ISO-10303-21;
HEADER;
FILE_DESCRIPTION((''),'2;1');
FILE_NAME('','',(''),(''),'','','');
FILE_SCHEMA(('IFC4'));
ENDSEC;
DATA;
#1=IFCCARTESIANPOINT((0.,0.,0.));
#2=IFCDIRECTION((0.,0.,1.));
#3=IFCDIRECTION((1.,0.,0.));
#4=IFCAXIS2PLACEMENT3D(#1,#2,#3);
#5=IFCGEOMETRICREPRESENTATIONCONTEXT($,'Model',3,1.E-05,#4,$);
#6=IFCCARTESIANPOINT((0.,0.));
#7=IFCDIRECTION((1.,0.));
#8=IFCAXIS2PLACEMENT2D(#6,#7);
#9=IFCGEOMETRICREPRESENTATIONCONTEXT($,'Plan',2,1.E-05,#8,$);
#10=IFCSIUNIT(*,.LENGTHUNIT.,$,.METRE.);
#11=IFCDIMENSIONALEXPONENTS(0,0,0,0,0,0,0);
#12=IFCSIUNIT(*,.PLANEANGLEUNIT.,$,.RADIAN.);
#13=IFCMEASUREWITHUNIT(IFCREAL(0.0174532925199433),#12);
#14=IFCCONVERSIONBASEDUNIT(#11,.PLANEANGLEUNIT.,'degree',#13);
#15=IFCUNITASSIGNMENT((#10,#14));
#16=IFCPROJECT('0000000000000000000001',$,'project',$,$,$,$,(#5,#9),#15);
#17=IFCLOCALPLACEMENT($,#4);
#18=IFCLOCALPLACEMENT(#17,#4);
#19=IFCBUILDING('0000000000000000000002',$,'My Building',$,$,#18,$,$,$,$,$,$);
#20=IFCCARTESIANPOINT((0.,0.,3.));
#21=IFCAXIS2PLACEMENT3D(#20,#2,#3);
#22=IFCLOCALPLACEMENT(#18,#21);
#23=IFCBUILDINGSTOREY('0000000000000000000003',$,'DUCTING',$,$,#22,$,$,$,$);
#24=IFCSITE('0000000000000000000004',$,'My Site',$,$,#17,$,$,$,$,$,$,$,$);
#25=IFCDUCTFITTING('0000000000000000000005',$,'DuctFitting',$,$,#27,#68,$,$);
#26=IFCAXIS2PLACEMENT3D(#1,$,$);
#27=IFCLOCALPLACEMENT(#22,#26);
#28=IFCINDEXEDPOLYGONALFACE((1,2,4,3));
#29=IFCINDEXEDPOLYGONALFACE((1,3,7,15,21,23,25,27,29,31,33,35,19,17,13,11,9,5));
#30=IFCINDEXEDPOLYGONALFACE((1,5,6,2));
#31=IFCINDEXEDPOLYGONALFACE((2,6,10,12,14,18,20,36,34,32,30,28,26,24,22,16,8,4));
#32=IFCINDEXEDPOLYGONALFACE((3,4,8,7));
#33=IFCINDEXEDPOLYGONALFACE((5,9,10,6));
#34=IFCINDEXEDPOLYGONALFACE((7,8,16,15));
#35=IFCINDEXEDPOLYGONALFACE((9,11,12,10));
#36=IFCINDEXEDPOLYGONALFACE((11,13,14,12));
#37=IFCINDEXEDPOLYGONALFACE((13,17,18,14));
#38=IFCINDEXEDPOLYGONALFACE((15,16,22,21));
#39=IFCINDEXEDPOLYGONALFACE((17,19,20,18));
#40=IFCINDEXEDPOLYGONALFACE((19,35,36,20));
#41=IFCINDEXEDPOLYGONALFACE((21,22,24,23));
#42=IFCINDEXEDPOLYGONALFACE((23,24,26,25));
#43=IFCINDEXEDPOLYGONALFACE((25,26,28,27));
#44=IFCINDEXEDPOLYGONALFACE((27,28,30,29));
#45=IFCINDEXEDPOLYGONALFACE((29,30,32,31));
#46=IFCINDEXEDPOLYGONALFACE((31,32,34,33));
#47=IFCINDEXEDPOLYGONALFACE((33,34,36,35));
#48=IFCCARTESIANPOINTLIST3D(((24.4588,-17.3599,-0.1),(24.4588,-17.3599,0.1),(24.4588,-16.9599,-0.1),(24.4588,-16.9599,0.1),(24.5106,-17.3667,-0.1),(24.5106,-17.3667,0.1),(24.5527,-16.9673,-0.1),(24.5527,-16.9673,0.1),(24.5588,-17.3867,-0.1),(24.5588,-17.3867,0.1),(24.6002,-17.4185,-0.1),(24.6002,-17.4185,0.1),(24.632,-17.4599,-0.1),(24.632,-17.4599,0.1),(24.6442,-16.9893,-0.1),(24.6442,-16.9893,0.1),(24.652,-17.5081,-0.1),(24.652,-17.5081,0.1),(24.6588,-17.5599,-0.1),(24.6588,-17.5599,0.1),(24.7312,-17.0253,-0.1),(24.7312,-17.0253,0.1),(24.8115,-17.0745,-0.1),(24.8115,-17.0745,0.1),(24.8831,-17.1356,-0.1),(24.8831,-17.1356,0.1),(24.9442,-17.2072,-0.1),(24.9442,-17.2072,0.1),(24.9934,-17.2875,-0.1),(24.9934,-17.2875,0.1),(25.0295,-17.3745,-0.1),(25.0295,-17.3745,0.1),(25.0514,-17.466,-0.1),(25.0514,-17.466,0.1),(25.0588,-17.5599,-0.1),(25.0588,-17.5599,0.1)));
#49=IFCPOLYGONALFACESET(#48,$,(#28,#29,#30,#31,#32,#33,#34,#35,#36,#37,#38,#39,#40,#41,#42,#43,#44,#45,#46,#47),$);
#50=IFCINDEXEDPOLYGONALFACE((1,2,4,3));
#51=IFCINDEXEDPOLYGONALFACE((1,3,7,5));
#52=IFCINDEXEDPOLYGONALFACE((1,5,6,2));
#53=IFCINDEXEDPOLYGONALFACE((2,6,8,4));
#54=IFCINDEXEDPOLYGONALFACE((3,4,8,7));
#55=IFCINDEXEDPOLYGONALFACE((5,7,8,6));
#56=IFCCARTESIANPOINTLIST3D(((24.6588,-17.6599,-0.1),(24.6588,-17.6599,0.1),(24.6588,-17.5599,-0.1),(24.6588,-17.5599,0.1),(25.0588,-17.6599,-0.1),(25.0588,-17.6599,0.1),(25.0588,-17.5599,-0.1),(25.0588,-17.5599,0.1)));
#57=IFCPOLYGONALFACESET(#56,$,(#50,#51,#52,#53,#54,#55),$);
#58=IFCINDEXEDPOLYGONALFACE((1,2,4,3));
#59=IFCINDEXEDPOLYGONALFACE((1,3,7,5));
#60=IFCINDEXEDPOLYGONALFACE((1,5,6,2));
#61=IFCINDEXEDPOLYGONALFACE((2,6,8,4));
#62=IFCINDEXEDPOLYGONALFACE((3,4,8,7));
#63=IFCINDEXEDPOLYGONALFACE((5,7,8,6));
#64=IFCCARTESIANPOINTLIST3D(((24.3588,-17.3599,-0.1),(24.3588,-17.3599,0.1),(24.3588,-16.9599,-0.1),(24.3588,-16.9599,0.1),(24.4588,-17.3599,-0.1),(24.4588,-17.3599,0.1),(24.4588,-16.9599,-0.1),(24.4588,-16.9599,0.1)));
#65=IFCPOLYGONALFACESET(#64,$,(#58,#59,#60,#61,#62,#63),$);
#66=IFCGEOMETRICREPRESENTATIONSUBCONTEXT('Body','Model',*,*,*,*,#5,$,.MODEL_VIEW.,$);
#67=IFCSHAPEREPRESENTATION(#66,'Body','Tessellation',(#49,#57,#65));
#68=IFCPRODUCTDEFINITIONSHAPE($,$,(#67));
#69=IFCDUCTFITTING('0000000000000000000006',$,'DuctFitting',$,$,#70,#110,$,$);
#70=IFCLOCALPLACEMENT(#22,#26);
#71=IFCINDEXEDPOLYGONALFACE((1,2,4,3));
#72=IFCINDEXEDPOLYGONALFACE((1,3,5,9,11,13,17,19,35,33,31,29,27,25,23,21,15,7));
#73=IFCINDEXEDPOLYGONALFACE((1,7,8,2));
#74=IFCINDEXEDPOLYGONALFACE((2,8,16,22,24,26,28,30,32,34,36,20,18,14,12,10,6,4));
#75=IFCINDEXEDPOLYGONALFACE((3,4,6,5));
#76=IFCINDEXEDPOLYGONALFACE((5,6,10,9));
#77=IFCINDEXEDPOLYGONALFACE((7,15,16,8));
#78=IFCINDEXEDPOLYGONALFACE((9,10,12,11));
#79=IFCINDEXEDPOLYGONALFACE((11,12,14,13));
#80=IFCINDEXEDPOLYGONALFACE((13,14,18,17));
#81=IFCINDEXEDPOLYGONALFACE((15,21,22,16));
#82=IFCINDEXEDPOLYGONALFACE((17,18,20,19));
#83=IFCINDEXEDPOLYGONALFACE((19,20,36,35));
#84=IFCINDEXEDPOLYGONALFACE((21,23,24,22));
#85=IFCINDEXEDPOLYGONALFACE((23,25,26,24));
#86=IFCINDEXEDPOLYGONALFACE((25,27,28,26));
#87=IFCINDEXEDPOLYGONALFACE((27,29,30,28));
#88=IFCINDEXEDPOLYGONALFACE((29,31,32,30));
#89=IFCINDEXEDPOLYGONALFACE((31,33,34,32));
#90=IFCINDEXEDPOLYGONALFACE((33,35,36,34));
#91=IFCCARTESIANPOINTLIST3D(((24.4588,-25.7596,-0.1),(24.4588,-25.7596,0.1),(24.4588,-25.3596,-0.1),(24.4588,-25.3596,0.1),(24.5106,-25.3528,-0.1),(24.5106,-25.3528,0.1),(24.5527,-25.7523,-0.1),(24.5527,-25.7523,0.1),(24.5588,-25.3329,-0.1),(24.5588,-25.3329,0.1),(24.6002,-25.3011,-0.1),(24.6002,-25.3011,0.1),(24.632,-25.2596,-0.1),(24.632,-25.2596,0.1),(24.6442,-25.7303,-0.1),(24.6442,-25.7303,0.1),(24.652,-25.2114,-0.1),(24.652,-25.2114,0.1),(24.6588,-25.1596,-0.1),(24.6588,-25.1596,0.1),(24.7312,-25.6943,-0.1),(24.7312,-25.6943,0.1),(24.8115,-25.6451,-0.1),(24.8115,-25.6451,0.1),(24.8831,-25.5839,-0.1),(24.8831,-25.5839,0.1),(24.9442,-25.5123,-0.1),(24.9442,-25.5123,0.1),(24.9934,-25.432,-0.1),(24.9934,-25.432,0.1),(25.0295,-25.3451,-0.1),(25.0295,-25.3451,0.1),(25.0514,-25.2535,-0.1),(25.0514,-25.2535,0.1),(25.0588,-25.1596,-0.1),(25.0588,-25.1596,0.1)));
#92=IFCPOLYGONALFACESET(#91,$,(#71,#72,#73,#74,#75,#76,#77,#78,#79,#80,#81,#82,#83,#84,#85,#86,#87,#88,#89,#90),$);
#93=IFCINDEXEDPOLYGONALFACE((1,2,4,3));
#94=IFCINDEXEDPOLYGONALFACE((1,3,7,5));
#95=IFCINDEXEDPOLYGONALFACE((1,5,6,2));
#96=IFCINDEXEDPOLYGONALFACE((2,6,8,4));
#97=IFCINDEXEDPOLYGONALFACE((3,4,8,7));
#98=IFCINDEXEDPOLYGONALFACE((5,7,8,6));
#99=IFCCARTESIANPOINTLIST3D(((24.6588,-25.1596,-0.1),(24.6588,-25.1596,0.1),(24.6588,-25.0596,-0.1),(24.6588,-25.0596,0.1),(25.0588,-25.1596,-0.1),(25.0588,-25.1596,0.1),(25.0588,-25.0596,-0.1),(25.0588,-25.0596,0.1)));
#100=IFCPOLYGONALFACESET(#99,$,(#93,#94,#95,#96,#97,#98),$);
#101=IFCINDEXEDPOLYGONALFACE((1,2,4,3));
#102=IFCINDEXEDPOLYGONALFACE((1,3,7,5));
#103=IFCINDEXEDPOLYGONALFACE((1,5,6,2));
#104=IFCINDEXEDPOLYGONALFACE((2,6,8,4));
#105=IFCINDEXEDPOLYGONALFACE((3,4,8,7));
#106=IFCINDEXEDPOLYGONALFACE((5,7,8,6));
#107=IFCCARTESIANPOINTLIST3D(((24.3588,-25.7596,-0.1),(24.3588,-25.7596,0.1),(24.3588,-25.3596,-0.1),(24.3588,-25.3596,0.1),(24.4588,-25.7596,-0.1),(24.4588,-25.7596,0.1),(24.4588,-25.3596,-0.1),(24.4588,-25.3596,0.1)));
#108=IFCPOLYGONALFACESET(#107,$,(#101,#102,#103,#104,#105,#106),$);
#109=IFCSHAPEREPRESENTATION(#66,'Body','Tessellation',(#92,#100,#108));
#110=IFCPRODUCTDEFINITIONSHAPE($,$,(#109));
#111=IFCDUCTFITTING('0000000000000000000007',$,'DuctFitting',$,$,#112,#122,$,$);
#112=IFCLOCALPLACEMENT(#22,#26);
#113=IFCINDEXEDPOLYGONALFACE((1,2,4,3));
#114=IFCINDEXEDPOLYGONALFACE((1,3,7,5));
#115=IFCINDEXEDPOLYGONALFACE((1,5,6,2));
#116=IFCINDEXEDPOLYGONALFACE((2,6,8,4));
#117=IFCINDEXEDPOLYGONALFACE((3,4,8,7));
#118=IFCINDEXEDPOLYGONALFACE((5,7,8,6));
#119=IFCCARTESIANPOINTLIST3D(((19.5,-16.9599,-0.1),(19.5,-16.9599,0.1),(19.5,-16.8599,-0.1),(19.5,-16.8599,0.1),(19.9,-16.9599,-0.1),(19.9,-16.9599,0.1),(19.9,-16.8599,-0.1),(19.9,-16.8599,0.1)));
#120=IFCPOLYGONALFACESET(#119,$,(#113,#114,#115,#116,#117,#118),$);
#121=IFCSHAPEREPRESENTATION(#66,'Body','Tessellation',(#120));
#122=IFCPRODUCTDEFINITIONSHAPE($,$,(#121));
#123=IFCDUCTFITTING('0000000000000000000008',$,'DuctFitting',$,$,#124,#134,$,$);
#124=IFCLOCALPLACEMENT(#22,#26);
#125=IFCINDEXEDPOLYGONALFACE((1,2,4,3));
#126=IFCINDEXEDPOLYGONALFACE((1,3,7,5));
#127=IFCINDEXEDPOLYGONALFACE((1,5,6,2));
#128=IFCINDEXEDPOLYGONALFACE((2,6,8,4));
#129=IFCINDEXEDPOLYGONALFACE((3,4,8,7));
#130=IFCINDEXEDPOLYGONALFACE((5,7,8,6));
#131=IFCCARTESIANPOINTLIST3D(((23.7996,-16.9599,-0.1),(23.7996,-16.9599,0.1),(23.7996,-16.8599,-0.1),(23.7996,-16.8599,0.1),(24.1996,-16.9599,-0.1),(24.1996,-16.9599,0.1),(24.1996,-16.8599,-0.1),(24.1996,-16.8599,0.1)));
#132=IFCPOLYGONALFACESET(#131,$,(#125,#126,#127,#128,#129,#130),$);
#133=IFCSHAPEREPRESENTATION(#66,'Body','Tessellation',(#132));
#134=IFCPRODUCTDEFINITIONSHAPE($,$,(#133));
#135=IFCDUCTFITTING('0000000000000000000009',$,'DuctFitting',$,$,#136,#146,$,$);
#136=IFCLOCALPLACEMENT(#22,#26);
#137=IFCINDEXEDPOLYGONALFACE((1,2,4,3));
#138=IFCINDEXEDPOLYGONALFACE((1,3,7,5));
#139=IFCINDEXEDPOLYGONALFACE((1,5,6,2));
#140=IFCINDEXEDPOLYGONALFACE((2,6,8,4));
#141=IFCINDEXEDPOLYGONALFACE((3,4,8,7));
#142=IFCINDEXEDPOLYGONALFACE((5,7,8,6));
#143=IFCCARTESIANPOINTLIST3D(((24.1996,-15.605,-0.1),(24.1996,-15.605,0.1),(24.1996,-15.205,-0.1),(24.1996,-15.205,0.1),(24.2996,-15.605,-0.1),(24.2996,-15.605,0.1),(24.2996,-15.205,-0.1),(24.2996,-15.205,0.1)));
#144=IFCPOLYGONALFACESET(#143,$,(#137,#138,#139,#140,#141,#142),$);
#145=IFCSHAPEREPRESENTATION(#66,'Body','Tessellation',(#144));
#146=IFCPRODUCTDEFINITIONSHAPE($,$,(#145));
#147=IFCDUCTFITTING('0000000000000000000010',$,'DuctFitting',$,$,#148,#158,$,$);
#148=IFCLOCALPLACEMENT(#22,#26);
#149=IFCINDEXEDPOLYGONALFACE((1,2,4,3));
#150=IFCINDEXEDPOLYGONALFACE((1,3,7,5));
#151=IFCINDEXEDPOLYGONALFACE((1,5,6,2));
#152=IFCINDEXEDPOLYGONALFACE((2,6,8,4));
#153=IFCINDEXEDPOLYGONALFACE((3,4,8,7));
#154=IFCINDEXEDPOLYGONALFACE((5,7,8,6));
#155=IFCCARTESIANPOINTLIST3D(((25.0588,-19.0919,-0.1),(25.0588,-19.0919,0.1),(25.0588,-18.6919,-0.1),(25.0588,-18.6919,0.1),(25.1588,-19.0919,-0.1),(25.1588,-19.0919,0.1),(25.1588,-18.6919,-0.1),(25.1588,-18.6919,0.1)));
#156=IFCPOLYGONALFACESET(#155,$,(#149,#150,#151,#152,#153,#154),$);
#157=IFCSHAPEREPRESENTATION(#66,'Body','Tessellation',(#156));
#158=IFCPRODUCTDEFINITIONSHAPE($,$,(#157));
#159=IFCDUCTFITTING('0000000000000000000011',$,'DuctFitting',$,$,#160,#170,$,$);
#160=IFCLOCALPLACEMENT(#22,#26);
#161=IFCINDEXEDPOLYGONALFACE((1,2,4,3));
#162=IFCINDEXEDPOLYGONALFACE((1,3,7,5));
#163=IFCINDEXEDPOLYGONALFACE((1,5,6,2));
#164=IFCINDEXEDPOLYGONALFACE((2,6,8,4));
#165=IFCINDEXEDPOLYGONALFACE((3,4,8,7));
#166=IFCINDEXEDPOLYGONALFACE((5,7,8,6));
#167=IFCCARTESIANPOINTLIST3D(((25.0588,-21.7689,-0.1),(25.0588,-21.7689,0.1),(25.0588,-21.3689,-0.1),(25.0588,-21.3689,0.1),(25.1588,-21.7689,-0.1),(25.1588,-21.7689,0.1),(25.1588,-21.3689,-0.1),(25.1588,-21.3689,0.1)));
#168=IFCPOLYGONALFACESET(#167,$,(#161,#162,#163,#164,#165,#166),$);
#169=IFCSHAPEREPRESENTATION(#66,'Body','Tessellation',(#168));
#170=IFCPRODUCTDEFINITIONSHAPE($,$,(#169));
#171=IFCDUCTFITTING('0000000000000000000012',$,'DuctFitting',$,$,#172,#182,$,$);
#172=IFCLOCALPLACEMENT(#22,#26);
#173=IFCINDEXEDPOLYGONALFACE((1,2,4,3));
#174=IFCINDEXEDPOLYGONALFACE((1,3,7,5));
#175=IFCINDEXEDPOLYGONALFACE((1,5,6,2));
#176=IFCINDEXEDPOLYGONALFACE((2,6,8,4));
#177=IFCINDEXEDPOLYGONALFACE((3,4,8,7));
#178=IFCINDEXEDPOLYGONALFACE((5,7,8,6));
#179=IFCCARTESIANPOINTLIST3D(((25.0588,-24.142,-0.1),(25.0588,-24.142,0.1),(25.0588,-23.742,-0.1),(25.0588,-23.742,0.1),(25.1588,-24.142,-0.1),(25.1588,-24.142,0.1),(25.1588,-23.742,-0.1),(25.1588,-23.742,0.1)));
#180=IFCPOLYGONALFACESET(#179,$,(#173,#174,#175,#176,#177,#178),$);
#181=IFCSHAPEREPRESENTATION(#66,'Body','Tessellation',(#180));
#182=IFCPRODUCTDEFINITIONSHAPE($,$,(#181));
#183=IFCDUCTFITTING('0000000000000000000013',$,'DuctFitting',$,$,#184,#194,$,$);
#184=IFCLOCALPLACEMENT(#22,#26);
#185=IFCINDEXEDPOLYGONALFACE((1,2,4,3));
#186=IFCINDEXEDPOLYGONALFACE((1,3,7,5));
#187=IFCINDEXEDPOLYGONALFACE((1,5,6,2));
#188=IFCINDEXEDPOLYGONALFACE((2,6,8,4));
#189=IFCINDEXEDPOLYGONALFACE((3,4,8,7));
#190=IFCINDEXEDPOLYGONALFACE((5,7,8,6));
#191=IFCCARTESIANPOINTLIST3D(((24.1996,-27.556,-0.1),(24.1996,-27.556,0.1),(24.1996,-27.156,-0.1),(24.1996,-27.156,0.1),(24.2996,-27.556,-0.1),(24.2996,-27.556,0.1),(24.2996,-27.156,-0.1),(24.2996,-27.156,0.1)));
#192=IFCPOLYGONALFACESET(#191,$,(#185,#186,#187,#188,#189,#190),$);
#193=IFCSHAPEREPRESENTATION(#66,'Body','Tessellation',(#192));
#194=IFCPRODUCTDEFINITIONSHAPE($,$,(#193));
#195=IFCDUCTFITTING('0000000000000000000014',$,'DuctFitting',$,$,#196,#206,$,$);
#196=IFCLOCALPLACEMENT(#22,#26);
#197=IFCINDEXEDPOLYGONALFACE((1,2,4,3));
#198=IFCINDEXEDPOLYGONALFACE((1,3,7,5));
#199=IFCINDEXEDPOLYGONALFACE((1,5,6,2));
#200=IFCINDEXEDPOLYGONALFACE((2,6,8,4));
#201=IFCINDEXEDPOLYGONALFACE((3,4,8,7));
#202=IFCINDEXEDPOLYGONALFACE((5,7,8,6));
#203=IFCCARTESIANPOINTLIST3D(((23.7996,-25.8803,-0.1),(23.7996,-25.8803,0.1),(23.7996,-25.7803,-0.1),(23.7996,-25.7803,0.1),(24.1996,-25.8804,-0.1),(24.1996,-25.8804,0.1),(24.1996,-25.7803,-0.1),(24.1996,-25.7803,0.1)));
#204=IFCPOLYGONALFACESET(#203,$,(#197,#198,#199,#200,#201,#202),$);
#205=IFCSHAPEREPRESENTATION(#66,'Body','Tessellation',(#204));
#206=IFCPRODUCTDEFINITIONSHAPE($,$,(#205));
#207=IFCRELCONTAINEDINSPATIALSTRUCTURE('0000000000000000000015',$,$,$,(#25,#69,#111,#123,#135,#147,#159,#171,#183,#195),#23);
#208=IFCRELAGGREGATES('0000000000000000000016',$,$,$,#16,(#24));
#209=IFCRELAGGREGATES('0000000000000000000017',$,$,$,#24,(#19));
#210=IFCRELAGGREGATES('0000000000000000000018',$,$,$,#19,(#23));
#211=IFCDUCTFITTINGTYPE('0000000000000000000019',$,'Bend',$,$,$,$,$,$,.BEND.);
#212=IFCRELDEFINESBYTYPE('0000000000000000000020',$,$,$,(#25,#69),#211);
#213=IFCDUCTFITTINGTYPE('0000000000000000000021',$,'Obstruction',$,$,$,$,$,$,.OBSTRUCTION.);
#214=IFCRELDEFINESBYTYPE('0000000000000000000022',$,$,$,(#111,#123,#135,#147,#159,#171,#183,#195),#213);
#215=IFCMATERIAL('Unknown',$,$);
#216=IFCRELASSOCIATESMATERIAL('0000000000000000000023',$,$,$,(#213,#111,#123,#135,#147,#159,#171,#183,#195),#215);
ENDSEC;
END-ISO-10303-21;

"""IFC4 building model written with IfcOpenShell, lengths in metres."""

from ifc_helpers import new_model, entity, si_unit, converted_unit, frame, origin_with_axes, origin_2d_with_axis, place, context, subcontext, project, spatial, line, arc, indexed_curve, rectangle, outline, extrude, source, transform, mapped, material, material_profile, profile_set, profile_usage, type_object, type_shapes, element, save


model = new_model("IFC4")

# Units and contexts
model_context = context("Model", 3, precision=1e-05, world=origin_with_axes())
plan_context = context("Plan", 2, precision=1e-05, world=origin_2d_with_axis())
body_context = subcontext(model_context, "Body", "Model", "MODEL_VIEW")
ifc_project = project(units=[si_unit("LENGTHUNIT", "METRE"), converted_unit("PLANEANGLEUNIT", "degree", entity("IfcReal", 0.0174532925199433), si_unit("PLANEANGLEUNIT", "RADIAN"), dimensions=[0, 0, 0, 0, 0, 0, 0])], contexts=[model_context, plan_context])

# Site, building, storey
site_placement = place(None, origin_with_axes())
site = spatial("IfcSite", under=ifc_project, at=site_placement, Name="My Site")
building_placement = place(site_placement, origin_with_axes())
building = spatial("IfcBuilding", under=site, at=building_placement, Name="My Building")
storey_placement = place(building_placement, frame((0.0, 0.0, 3.0), z_axis=(0.0, 0.0, 1.0), x_axis=(1.0, 0.0, 0.0)))
storey = spatial("IfcBuildingStorey", under=building, at=storey_placement, Name="DUCTING")

# Shared definitions
ifc_material = material(Name="Unknown")

# Duct fittings
duct_fitting_type_1 = type_object("IfcDuctFittingType", Name="Bend", PredefinedType="BEND")
shared_shape = source(origin_with_axes(), body_context, "Body", "SweptSolid", [
    extrude(outline(indexed_curve([(0.2, 0.0), (0.2586, 0.1414), (0.4, 0.2), (0.4, 0.6), (-0.0243, 0.4243), (-0.2, 0.0)], segments=[arc(1, 2, 3), line(3, 4), arc(4, 5, 6), line(6, 1)])), frame((0.0, -0.1, 0.1), z_axis=(0.0, -1.0, 0.0), x_axis=(1.0, 0.0, 0.0)), (0.0, 0.0, -1.0), 0.2),
    extrude(rectangle(XDim=0.4, YDim=0.2), origin_with_axes(), (0.0, 0.0, 1.0), 0.1),
    extrude(rectangle(XDim=0.4, YDim=0.2), frame((0.4, 0.0, 0.5), z_axis=(1.0, 0.0, 0.0), x_axis=(0.0, 0.0, 1.0)), (0.0, 0.0, 1.0), 0.1),
])
type_shapes(duct_fitting_type_1, [shared_shape])
for number, where, z_axis, x_axis, name in (
    (1, (24.8588, -17.6599, 0.0), (0.0, 1.0, 0.0), (-1.0, 0.0, 0.0), "DuctFitting"),
    (2, (24.8588, -25.0596, 0.0), (0.0, -1.0, 0.0), (-1.0, 0.0, 0.0), "DuctFitting"),
):
    element("IfcDuctFitting", number, at=place(storey_placement, frame(where, z_axis=z_axis, x_axis=x_axis)), inside=storey, type_object=duct_fitting_type_1, Name=name, context=body_context, shape_type="MappedRepresentation", body=[
        mapped(shared_shape, transform((0.0, 0.0, 0.0), x_axis=(1.0, 0.0, 0.0), y_axis=(0.0, 1.0, 0.0), z_axis=(0.0, 0.0, 1.0), scale=1.0)),
    ])
ifc_material_profile_1 = material_profile(ifc_material, rectangle(XDim=0.4, YDim=0.2))
ifc_profile_set_1 = profile_set([ifc_material_profile_1])
ifc_profile_usage_1 = profile_usage(ifc_profile_set_1, cardinal=5)
duct_fitting_type_2 = type_object("IfcDuctFittingType", Name="Obstruction", PredefinedType="OBSTRUCTION", material=ifc_profile_set_1)
duct_fitting_1_placement = place(storey_placement, frame((19.7, -16.8599, 0.0), z_axis=(0.0, -1.0, 0.0), x_axis=(1.0, 0.0, 0.0)))
element("IfcDuctFitting", 3, at=duct_fitting_1_placement, inside=storey, type_object=duct_fitting_type_2, material=ifc_profile_usage_1, Name="DuctFitting", context=body_context, shape_type="SweptSolid", body=[
    extrude(rectangle(XDim=0.4, YDim=0.2), origin_with_axes(), (0.0, 0.0, 1.0), 0.1),
])
ifc_profile_usage_2 = profile_usage(ifc_profile_set_1, cardinal=5)
duct_fitting_2_placement = place(storey_placement, frame((23.9996, -16.8599, 0.0), z_axis=(0.0, -1.0, 0.0), x_axis=(1.0, 0.0, 0.0)))
element("IfcDuctFitting", 4, at=duct_fitting_2_placement, inside=storey, type_object=duct_fitting_type_2, material=ifc_profile_usage_2, Name="DuctFitting", context=body_context, shape_type="SweptSolid", body=[
    extrude(rectangle(XDim=0.4, YDim=0.2), origin_with_axes(), (0.0, 0.0, 1.0), 0.1),
])
ifc_profile_usage_3 = profile_usage(ifc_profile_set_1, cardinal=5)
duct_fitting_3_placement = place(storey_placement, frame((24.2996, -15.405, 0.0), z_axis=(-1.0, 0.0, 0.0), x_axis=(0.0, -1.0, 0.0)))
element("IfcDuctFitting", 5, at=duct_fitting_3_placement, inside=storey, type_object=duct_fitting_type_2, material=ifc_profile_usage_3, Name="DuctFitting", context=body_context, shape_type="SweptSolid", body=[
    extrude(rectangle(XDim=0.4, YDim=0.2), origin_with_axes(), (0.0, 0.0, 1.0), 0.1),
])
ifc_profile_usage_4 = profile_usage(ifc_profile_set_1, cardinal=5)
duct_fitting_4_placement = place(storey_placement, frame((25.1588, -18.8919, 0.0), z_axis=(-1.0, 0.0, 0.0), x_axis=(0.0, -1.0, 0.0)))
element("IfcDuctFitting", 6, at=duct_fitting_4_placement, inside=storey, type_object=duct_fitting_type_2, material=ifc_profile_usage_4, Name="DuctFitting", context=body_context, shape_type="SweptSolid", body=[
    extrude(rectangle(XDim=0.4, YDim=0.2), origin_with_axes(), (0.0, 0.0, 1.0), 0.1),
])
ifc_profile_usage_5 = profile_usage(ifc_profile_set_1, cardinal=5)
duct_fitting_5_placement = place(storey_placement, frame((25.1588, -21.5689, 0.0), z_axis=(-1.0, 0.0, 0.0), x_axis=(0.0, -1.0, 0.0)))
element("IfcDuctFitting", 7, at=duct_fitting_5_placement, inside=storey, type_object=duct_fitting_type_2, material=ifc_profile_usage_5, Name="DuctFitting", context=body_context, shape_type="SweptSolid", body=[
    extrude(rectangle(XDim=0.4, YDim=0.2), origin_with_axes(), (0.0, 0.0, 1.0), 0.1),
])
ifc_profile_usage_6 = profile_usage(ifc_profile_set_1, cardinal=5)
duct_fitting_6_placement = place(storey_placement, frame((25.1588, -23.942, 0.0), z_axis=(-1.0, 0.0, 0.0), x_axis=(0.0, -1.0, 0.0)))
element("IfcDuctFitting", 8, at=duct_fitting_6_placement, inside=storey, type_object=duct_fitting_type_2, material=ifc_profile_usage_6, Name="DuctFitting", context=body_context, shape_type="SweptSolid", body=[
    extrude(rectangle(XDim=0.4, YDim=0.2), origin_with_axes(), (0.0, 0.0, 1.0), 0.1),
])
ifc_profile_usage_7 = profile_usage(ifc_profile_set_1, cardinal=5)
duct_fitting_7_placement = place(storey_placement, frame((24.2996, -27.356, 0.0), z_axis=(-1.0, 0.000001, 0.0), x_axis=(-0.000001, -1.0, 0.0)))
element("IfcDuctFitting", 9, at=duct_fitting_7_placement, inside=storey, type_object=duct_fitting_type_2, material=ifc_profile_usage_7, Name="DuctFitting", context=body_context, shape_type="SweptSolid", body=[
    extrude(rectangle(XDim=0.4, YDim=0.2), origin_with_axes(), (0.0, 0.0, 1.0), 0.1),
])
ifc_profile_usage_8 = profile_usage(ifc_profile_set_1, cardinal=5)
duct_fitting_8_placement = place(storey_placement, frame((23.9996, -25.8804, 0.0), z_axis=(0.000001, 1.0, 0.0), x_axis=(-1.0, 0.000001, 0.0)))
element("IfcDuctFitting", 10, at=duct_fitting_8_placement, inside=storey, type_object=duct_fitting_type_2, material=ifc_profile_usage_8, Name="DuctFitting", context=body_context, shape_type="SweptSolid", body=[
    extrude(rectangle(XDim=0.4, YDim=0.2), origin_with_axes(), (0.0, 0.0, 1.0), 0.1),
])

save(model, "model.ifc")
